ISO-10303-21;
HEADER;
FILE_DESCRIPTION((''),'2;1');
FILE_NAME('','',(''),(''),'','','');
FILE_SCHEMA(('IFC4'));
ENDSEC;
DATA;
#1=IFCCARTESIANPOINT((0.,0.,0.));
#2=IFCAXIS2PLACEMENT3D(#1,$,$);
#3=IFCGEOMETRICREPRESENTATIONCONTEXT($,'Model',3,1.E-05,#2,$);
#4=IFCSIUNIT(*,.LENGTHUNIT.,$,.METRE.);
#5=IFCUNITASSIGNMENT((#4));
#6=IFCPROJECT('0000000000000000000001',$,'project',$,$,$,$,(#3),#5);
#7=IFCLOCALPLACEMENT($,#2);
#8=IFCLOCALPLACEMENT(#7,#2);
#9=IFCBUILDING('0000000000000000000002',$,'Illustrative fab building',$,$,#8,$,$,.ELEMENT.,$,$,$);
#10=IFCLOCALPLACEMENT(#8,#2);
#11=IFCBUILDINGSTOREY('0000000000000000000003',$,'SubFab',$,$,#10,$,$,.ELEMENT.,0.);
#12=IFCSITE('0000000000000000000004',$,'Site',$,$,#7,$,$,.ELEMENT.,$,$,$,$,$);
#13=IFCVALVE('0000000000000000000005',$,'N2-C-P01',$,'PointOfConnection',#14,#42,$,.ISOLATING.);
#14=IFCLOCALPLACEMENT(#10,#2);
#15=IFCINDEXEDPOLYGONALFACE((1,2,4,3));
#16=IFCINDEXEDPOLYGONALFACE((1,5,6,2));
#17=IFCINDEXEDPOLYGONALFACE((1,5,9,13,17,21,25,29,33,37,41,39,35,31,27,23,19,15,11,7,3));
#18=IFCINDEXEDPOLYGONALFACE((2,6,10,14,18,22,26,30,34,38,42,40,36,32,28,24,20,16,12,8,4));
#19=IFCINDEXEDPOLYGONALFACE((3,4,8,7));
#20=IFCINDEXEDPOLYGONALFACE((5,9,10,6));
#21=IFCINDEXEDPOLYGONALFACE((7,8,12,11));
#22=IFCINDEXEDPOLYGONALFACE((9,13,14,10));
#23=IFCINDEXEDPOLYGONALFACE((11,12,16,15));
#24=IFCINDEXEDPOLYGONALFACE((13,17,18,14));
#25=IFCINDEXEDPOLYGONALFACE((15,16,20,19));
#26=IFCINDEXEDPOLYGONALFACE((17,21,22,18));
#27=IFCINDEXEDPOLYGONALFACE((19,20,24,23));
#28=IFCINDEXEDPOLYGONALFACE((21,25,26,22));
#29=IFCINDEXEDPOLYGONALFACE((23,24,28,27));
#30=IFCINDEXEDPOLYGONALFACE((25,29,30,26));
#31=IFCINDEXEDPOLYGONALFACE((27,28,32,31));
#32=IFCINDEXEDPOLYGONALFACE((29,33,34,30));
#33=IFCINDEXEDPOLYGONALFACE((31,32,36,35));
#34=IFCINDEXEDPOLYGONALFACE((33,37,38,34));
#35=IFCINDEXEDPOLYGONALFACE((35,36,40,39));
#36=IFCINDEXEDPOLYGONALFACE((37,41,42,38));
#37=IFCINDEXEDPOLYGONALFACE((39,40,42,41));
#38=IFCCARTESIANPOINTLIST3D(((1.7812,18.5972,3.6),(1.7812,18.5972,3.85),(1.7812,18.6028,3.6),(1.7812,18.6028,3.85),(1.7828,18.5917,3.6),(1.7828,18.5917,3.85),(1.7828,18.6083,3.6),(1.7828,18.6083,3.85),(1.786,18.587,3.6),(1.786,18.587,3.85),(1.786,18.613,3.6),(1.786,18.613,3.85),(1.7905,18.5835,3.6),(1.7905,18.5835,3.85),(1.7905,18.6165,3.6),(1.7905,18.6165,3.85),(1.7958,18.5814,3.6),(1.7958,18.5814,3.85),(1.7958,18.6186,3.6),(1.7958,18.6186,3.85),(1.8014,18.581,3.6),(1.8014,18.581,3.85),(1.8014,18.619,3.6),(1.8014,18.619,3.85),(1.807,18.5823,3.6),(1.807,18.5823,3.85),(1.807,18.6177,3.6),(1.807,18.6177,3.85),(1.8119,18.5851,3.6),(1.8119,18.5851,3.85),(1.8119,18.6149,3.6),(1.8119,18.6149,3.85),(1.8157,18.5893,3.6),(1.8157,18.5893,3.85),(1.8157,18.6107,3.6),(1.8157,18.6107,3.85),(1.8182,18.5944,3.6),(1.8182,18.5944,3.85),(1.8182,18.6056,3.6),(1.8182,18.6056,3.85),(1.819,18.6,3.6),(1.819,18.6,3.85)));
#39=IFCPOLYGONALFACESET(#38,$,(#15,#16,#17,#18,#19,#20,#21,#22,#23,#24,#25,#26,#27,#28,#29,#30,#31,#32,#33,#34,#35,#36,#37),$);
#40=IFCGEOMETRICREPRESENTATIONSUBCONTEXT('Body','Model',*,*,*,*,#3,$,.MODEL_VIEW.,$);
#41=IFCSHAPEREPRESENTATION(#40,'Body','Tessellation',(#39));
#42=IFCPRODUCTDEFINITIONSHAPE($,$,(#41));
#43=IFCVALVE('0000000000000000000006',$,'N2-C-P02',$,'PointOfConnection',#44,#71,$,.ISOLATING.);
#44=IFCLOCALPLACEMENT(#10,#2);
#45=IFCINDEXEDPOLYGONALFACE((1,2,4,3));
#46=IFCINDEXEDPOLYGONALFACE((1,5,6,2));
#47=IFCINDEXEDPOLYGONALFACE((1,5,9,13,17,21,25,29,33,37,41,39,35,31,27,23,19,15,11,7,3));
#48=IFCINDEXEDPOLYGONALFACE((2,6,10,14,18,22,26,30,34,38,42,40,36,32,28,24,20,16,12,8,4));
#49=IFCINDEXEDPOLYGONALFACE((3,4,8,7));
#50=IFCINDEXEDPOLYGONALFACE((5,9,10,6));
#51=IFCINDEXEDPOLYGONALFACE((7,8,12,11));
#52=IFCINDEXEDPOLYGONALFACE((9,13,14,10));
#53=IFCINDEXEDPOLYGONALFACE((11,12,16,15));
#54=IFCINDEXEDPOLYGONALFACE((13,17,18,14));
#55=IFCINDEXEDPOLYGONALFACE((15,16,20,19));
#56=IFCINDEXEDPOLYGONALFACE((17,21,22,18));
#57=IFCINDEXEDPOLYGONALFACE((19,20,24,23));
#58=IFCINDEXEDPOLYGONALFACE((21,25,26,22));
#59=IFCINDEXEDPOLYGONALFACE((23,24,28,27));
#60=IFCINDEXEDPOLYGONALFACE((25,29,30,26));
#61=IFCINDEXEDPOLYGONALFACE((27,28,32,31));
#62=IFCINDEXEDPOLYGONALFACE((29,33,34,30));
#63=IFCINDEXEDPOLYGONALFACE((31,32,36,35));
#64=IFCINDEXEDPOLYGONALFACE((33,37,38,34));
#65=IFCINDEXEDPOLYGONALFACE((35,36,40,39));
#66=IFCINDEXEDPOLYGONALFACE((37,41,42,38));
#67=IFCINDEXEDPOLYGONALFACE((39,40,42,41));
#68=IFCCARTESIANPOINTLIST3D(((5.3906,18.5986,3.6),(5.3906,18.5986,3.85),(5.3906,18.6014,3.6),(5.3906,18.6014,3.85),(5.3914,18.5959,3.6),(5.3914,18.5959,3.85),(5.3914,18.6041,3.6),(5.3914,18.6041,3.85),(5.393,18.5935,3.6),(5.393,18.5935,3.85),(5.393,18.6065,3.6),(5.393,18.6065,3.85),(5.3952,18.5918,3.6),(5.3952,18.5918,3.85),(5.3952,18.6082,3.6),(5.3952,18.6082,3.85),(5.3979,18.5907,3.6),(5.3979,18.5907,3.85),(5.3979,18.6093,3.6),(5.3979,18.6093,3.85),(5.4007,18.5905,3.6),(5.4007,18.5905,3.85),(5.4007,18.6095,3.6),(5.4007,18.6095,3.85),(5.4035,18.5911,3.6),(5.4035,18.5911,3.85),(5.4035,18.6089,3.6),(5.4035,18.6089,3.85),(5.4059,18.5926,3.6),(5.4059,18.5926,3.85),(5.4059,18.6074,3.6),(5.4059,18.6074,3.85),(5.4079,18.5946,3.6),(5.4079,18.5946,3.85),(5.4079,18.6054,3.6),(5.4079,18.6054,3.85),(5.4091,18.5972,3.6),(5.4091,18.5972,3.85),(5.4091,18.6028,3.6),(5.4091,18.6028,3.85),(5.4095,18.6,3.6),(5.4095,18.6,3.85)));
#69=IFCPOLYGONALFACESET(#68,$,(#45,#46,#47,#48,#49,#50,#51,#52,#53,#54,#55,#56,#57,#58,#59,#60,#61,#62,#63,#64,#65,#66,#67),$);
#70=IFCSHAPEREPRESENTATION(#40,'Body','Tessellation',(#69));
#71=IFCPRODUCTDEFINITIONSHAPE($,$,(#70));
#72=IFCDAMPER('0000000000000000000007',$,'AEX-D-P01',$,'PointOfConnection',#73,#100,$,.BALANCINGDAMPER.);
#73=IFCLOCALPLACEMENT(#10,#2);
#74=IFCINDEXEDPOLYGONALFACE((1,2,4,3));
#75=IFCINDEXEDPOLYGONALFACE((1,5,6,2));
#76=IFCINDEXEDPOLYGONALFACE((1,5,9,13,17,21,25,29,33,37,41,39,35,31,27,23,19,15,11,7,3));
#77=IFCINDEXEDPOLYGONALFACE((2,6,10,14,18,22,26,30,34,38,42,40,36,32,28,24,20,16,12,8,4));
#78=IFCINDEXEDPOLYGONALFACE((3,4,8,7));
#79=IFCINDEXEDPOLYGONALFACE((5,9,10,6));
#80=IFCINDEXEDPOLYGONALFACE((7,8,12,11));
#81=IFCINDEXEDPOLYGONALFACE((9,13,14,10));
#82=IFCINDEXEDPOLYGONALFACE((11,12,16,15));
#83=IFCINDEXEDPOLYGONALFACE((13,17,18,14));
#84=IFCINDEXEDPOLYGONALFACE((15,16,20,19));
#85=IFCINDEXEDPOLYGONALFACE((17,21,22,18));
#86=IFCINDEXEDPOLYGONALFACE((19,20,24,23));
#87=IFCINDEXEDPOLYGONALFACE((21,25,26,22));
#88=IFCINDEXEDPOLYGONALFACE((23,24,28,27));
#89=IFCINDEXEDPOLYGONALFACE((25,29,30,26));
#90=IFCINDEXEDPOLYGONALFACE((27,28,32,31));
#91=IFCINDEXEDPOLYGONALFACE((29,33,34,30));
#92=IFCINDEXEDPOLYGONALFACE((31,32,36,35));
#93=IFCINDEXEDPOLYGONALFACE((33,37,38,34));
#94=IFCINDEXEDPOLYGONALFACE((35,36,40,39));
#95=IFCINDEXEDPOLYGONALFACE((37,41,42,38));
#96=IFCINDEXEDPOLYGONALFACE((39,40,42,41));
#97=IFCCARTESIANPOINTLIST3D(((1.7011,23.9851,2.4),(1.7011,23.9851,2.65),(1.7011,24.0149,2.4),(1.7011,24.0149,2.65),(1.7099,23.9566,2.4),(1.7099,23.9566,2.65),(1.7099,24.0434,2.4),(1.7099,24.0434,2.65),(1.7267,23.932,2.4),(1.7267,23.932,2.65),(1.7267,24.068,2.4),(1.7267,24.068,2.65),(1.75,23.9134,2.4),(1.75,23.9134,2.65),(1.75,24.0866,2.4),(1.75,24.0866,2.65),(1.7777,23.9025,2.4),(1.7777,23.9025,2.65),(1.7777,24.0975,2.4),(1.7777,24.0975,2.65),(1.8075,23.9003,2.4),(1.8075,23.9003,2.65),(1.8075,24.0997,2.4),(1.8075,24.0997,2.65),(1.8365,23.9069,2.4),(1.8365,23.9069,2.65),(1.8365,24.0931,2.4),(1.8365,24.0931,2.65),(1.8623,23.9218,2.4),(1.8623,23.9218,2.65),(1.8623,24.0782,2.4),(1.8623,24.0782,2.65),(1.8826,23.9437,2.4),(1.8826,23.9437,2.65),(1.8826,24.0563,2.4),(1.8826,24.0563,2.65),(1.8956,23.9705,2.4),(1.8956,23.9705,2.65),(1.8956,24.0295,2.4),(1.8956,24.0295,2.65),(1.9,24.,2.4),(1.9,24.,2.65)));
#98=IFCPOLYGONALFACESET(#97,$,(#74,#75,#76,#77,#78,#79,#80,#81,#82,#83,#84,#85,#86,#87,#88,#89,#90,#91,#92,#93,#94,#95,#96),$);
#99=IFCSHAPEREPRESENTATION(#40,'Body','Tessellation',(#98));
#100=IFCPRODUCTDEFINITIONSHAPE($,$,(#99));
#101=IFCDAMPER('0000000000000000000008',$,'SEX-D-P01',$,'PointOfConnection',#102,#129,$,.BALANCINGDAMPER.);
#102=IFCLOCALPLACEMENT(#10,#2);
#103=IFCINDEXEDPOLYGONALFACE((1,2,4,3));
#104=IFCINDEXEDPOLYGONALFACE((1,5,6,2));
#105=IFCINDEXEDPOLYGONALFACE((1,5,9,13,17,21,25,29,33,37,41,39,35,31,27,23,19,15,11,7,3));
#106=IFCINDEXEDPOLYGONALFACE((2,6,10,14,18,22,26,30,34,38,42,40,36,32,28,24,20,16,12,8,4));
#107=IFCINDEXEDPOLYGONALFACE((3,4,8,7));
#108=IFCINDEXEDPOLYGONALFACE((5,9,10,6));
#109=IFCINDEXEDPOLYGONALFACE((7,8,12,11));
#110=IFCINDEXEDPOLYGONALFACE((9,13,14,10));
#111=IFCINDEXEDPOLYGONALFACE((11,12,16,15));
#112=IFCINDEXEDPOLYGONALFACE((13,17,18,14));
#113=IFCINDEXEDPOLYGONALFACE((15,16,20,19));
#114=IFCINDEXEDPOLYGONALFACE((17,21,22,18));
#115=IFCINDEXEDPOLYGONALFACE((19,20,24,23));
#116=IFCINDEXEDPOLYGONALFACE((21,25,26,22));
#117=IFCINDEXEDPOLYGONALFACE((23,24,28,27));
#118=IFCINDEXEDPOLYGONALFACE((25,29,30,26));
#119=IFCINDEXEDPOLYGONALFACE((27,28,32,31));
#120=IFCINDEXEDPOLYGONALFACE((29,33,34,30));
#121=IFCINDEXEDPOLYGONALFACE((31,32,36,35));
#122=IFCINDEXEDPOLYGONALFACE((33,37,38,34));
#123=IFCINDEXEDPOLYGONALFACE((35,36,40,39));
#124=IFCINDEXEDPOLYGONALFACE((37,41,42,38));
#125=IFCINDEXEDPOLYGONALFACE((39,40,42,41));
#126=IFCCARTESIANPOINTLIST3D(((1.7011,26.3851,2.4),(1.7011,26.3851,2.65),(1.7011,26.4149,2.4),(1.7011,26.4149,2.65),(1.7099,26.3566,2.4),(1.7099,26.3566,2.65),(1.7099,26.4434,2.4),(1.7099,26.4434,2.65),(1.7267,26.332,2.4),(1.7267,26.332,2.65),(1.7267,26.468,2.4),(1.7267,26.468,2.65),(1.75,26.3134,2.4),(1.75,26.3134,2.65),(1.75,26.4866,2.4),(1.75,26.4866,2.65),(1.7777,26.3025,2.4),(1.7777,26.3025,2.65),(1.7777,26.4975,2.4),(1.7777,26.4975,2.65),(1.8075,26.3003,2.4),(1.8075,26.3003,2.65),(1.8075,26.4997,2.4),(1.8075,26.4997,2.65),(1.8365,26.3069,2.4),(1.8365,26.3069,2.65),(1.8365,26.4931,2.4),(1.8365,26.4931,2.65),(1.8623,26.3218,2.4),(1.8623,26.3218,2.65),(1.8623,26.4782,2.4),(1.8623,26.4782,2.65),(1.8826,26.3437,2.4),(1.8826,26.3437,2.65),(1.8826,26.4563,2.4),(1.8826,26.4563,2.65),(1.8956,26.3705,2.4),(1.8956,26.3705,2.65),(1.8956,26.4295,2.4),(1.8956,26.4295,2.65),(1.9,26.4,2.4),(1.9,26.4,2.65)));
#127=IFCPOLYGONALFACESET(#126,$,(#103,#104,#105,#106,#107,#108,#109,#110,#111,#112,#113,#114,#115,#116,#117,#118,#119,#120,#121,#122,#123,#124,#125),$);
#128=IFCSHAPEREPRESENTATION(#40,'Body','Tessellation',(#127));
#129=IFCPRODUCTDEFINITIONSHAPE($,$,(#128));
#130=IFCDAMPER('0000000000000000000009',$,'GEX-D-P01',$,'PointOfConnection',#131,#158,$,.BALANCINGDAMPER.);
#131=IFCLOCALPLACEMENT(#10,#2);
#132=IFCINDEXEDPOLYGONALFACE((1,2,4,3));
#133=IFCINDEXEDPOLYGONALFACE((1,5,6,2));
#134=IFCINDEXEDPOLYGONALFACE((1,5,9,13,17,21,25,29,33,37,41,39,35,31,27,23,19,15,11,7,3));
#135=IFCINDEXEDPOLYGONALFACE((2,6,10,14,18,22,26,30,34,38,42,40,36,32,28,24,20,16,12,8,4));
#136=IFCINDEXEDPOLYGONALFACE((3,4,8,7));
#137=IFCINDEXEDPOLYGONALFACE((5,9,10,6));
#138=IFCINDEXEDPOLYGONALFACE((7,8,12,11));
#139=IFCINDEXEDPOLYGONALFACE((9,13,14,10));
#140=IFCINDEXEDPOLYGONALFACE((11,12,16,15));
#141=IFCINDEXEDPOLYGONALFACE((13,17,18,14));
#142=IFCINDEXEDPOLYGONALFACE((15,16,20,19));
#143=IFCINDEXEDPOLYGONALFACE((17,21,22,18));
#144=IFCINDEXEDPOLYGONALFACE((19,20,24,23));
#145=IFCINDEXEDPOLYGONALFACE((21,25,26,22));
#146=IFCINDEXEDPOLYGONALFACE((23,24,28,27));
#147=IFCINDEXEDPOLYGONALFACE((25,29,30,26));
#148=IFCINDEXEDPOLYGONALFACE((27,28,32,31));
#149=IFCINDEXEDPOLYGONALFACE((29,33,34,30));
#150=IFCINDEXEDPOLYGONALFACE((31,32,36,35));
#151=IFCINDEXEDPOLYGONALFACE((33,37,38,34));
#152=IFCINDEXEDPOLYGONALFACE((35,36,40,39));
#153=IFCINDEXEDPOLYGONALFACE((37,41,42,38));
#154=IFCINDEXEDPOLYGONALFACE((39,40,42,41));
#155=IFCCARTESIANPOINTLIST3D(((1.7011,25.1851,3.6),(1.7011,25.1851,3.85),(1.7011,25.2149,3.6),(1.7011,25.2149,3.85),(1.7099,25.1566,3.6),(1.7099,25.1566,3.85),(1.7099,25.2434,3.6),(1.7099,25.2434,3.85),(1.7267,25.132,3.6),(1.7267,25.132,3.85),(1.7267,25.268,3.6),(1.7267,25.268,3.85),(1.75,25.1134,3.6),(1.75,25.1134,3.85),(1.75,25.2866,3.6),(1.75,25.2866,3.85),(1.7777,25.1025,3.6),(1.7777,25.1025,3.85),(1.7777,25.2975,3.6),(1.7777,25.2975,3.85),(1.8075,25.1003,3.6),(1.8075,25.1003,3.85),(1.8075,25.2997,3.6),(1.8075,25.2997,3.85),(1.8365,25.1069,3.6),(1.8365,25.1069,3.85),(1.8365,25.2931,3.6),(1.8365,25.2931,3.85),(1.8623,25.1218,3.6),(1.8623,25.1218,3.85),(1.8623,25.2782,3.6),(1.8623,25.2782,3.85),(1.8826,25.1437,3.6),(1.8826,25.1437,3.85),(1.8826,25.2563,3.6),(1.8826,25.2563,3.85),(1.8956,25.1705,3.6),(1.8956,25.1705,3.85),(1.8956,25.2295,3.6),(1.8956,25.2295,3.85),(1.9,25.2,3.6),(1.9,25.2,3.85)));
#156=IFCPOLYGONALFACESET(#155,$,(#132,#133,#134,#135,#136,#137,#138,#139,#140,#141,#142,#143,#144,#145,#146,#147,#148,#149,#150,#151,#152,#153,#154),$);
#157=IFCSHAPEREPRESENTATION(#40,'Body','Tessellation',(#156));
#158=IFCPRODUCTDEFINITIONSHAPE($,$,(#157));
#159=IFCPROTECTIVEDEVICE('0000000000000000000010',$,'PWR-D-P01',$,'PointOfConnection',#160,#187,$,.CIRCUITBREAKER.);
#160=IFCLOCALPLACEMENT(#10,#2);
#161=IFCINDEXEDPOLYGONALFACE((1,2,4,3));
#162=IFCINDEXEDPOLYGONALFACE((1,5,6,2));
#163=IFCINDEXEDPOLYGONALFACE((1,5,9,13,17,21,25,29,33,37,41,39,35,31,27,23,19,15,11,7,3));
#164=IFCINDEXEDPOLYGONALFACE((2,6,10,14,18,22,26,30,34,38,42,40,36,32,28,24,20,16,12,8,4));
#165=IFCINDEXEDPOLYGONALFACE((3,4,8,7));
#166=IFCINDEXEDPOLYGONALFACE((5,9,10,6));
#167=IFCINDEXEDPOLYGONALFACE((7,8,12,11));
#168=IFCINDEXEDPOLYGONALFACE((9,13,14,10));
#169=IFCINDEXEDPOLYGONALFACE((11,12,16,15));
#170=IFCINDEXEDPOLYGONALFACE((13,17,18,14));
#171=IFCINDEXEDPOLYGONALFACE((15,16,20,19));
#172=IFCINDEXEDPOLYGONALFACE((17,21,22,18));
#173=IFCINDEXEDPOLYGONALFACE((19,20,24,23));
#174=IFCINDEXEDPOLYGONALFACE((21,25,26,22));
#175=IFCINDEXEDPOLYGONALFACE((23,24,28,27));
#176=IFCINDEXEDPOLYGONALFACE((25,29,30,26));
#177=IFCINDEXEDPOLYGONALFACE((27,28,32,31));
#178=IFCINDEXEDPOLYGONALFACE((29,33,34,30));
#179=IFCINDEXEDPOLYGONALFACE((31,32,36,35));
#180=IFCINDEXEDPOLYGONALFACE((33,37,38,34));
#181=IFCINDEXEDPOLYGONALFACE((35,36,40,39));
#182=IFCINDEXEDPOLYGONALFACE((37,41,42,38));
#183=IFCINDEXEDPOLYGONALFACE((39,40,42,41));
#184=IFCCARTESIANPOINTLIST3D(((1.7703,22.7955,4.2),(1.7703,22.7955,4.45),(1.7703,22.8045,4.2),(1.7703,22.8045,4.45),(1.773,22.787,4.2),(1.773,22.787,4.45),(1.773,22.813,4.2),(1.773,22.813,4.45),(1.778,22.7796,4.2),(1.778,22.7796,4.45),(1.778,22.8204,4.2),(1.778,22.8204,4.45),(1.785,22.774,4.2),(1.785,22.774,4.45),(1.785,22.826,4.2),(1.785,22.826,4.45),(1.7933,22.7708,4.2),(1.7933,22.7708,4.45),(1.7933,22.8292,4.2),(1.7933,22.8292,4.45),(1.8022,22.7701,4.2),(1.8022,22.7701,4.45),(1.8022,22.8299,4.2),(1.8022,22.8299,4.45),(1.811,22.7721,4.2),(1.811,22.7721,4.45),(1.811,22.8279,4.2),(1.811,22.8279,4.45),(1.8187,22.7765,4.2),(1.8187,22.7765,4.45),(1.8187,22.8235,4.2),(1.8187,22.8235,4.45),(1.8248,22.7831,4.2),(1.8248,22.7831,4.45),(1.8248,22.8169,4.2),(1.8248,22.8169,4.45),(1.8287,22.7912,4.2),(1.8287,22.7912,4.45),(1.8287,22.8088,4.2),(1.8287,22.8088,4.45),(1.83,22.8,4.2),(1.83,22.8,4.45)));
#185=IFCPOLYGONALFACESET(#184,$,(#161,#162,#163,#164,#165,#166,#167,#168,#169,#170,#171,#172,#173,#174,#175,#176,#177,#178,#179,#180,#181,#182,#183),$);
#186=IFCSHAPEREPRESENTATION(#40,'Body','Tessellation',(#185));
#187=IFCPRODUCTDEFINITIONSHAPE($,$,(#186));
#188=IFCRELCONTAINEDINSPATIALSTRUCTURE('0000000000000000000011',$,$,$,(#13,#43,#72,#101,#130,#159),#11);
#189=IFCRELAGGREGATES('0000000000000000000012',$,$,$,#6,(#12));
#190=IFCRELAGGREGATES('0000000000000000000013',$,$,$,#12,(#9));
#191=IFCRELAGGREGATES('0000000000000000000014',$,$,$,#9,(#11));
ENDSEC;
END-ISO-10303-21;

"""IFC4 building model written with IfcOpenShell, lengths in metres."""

from ifc_helpers import new_model, entity, si_unit, frame, origin, place, context, subcontext, project, spatial, element, save


model = new_model("IFC4")

# Units and contexts
model_context = context("Model", 3, precision=1e-05, world=origin())
body_context = subcontext(model_context, "Body", "Model", "MODEL_VIEW")
ifc_project = project(units=[si_unit("LENGTHUNIT", "METRE")], contexts=[model_context])

# Site, building, storey
site_placement = place(None, origin())
site = spatial("IfcSite", under=ifc_project, at=site_placement, Name="Site", CompositionType="ELEMENT")
building_placement = place(site_placement, origin())
building = spatial("IfcBuilding", under=site, at=building_placement, Name="Illustrative fab building", CompositionType="ELEMENT")
storey_placement = place(building_placement, origin())
storey = spatial("IfcBuildingStorey", under=building, at=storey_placement, Name="SubFab", CompositionType="ELEMENT", Elevation=0.0)

# Valves
valve_1_placement = place(storey_placement, frame((1.8, 18.6, 3.6)))
element("IfcValve", 1, at=valve_1_placement, inside=storey, Name="N2-C-P01", ObjectType="PointOfConnection", PredefinedType="ISOLATING", context=body_context, shape_type="AdvancedSweptSolid", body=[
    entity("IfcSweptDiskSolid", entity("IfcPolyline", [entity("IfcCartesianPoint", [0.0, 0.0, 0.0]), entity("IfcCartesianPoint", [0.0, 0.0, 0.25])]), 0.019),
])
valve_2_placement = place(storey_placement, frame((5.4, 18.6, 3.6)))
element("IfcValve", 2, at=valve_2_placement, inside=storey, Name="N2-C-P02", ObjectType="PointOfConnection", PredefinedType="ISOLATING", context=body_context, shape_type="AdvancedSweptSolid", body=[
    entity("IfcSweptDiskSolid", entity("IfcPolyline", [entity("IfcCartesianPoint", [0.0, 0.0, 0.0]), entity("IfcCartesianPoint", [0.0, 0.0, 0.25])]), 0.0095),
])

# Dampers
for number, where, name in (
    (3, (1.8, 24.0, 2.4), "AEX-D-P01"),
    (4, (1.8, 26.4, 2.4), "SEX-D-P01"),
    (5, (1.8, 25.2, 3.6), "GEX-D-P01"),
):
    element("IfcDamper", number, at=place(storey_placement, frame(where)), inside=storey, Name=name, ObjectType="PointOfConnection", PredefinedType="BALANCINGDAMPER", context=body_context, shape_type="AdvancedSweptSolid", body=[
        entity("IfcSweptDiskSolid", entity("IfcPolyline", [entity("IfcCartesianPoint", [0.0, 0.0, 0.0]), entity("IfcCartesianPoint", [0.0, 0.0, 0.25])]), 0.1),
    ])

# Protective device
protective_device_placement = place(storey_placement, frame((1.8, 22.8, 4.2)))
element("IfcProtectiveDevice", 6, at=protective_device_placement, inside=storey, Name="PWR-D-P01", ObjectType="PointOfConnection", PredefinedType="CIRCUITBREAKER", context=body_context, shape_type="AdvancedSweptSolid", body=[
    entity("IfcSweptDiskSolid", entity("IfcPolyline", [entity("IfcCartesianPoint", [0.0, 0.0, 0.0]), entity("IfcCartesianPoint", [0.0, 0.0, 0.25])]), 0.03),
])

save(model, "model.ifc")
